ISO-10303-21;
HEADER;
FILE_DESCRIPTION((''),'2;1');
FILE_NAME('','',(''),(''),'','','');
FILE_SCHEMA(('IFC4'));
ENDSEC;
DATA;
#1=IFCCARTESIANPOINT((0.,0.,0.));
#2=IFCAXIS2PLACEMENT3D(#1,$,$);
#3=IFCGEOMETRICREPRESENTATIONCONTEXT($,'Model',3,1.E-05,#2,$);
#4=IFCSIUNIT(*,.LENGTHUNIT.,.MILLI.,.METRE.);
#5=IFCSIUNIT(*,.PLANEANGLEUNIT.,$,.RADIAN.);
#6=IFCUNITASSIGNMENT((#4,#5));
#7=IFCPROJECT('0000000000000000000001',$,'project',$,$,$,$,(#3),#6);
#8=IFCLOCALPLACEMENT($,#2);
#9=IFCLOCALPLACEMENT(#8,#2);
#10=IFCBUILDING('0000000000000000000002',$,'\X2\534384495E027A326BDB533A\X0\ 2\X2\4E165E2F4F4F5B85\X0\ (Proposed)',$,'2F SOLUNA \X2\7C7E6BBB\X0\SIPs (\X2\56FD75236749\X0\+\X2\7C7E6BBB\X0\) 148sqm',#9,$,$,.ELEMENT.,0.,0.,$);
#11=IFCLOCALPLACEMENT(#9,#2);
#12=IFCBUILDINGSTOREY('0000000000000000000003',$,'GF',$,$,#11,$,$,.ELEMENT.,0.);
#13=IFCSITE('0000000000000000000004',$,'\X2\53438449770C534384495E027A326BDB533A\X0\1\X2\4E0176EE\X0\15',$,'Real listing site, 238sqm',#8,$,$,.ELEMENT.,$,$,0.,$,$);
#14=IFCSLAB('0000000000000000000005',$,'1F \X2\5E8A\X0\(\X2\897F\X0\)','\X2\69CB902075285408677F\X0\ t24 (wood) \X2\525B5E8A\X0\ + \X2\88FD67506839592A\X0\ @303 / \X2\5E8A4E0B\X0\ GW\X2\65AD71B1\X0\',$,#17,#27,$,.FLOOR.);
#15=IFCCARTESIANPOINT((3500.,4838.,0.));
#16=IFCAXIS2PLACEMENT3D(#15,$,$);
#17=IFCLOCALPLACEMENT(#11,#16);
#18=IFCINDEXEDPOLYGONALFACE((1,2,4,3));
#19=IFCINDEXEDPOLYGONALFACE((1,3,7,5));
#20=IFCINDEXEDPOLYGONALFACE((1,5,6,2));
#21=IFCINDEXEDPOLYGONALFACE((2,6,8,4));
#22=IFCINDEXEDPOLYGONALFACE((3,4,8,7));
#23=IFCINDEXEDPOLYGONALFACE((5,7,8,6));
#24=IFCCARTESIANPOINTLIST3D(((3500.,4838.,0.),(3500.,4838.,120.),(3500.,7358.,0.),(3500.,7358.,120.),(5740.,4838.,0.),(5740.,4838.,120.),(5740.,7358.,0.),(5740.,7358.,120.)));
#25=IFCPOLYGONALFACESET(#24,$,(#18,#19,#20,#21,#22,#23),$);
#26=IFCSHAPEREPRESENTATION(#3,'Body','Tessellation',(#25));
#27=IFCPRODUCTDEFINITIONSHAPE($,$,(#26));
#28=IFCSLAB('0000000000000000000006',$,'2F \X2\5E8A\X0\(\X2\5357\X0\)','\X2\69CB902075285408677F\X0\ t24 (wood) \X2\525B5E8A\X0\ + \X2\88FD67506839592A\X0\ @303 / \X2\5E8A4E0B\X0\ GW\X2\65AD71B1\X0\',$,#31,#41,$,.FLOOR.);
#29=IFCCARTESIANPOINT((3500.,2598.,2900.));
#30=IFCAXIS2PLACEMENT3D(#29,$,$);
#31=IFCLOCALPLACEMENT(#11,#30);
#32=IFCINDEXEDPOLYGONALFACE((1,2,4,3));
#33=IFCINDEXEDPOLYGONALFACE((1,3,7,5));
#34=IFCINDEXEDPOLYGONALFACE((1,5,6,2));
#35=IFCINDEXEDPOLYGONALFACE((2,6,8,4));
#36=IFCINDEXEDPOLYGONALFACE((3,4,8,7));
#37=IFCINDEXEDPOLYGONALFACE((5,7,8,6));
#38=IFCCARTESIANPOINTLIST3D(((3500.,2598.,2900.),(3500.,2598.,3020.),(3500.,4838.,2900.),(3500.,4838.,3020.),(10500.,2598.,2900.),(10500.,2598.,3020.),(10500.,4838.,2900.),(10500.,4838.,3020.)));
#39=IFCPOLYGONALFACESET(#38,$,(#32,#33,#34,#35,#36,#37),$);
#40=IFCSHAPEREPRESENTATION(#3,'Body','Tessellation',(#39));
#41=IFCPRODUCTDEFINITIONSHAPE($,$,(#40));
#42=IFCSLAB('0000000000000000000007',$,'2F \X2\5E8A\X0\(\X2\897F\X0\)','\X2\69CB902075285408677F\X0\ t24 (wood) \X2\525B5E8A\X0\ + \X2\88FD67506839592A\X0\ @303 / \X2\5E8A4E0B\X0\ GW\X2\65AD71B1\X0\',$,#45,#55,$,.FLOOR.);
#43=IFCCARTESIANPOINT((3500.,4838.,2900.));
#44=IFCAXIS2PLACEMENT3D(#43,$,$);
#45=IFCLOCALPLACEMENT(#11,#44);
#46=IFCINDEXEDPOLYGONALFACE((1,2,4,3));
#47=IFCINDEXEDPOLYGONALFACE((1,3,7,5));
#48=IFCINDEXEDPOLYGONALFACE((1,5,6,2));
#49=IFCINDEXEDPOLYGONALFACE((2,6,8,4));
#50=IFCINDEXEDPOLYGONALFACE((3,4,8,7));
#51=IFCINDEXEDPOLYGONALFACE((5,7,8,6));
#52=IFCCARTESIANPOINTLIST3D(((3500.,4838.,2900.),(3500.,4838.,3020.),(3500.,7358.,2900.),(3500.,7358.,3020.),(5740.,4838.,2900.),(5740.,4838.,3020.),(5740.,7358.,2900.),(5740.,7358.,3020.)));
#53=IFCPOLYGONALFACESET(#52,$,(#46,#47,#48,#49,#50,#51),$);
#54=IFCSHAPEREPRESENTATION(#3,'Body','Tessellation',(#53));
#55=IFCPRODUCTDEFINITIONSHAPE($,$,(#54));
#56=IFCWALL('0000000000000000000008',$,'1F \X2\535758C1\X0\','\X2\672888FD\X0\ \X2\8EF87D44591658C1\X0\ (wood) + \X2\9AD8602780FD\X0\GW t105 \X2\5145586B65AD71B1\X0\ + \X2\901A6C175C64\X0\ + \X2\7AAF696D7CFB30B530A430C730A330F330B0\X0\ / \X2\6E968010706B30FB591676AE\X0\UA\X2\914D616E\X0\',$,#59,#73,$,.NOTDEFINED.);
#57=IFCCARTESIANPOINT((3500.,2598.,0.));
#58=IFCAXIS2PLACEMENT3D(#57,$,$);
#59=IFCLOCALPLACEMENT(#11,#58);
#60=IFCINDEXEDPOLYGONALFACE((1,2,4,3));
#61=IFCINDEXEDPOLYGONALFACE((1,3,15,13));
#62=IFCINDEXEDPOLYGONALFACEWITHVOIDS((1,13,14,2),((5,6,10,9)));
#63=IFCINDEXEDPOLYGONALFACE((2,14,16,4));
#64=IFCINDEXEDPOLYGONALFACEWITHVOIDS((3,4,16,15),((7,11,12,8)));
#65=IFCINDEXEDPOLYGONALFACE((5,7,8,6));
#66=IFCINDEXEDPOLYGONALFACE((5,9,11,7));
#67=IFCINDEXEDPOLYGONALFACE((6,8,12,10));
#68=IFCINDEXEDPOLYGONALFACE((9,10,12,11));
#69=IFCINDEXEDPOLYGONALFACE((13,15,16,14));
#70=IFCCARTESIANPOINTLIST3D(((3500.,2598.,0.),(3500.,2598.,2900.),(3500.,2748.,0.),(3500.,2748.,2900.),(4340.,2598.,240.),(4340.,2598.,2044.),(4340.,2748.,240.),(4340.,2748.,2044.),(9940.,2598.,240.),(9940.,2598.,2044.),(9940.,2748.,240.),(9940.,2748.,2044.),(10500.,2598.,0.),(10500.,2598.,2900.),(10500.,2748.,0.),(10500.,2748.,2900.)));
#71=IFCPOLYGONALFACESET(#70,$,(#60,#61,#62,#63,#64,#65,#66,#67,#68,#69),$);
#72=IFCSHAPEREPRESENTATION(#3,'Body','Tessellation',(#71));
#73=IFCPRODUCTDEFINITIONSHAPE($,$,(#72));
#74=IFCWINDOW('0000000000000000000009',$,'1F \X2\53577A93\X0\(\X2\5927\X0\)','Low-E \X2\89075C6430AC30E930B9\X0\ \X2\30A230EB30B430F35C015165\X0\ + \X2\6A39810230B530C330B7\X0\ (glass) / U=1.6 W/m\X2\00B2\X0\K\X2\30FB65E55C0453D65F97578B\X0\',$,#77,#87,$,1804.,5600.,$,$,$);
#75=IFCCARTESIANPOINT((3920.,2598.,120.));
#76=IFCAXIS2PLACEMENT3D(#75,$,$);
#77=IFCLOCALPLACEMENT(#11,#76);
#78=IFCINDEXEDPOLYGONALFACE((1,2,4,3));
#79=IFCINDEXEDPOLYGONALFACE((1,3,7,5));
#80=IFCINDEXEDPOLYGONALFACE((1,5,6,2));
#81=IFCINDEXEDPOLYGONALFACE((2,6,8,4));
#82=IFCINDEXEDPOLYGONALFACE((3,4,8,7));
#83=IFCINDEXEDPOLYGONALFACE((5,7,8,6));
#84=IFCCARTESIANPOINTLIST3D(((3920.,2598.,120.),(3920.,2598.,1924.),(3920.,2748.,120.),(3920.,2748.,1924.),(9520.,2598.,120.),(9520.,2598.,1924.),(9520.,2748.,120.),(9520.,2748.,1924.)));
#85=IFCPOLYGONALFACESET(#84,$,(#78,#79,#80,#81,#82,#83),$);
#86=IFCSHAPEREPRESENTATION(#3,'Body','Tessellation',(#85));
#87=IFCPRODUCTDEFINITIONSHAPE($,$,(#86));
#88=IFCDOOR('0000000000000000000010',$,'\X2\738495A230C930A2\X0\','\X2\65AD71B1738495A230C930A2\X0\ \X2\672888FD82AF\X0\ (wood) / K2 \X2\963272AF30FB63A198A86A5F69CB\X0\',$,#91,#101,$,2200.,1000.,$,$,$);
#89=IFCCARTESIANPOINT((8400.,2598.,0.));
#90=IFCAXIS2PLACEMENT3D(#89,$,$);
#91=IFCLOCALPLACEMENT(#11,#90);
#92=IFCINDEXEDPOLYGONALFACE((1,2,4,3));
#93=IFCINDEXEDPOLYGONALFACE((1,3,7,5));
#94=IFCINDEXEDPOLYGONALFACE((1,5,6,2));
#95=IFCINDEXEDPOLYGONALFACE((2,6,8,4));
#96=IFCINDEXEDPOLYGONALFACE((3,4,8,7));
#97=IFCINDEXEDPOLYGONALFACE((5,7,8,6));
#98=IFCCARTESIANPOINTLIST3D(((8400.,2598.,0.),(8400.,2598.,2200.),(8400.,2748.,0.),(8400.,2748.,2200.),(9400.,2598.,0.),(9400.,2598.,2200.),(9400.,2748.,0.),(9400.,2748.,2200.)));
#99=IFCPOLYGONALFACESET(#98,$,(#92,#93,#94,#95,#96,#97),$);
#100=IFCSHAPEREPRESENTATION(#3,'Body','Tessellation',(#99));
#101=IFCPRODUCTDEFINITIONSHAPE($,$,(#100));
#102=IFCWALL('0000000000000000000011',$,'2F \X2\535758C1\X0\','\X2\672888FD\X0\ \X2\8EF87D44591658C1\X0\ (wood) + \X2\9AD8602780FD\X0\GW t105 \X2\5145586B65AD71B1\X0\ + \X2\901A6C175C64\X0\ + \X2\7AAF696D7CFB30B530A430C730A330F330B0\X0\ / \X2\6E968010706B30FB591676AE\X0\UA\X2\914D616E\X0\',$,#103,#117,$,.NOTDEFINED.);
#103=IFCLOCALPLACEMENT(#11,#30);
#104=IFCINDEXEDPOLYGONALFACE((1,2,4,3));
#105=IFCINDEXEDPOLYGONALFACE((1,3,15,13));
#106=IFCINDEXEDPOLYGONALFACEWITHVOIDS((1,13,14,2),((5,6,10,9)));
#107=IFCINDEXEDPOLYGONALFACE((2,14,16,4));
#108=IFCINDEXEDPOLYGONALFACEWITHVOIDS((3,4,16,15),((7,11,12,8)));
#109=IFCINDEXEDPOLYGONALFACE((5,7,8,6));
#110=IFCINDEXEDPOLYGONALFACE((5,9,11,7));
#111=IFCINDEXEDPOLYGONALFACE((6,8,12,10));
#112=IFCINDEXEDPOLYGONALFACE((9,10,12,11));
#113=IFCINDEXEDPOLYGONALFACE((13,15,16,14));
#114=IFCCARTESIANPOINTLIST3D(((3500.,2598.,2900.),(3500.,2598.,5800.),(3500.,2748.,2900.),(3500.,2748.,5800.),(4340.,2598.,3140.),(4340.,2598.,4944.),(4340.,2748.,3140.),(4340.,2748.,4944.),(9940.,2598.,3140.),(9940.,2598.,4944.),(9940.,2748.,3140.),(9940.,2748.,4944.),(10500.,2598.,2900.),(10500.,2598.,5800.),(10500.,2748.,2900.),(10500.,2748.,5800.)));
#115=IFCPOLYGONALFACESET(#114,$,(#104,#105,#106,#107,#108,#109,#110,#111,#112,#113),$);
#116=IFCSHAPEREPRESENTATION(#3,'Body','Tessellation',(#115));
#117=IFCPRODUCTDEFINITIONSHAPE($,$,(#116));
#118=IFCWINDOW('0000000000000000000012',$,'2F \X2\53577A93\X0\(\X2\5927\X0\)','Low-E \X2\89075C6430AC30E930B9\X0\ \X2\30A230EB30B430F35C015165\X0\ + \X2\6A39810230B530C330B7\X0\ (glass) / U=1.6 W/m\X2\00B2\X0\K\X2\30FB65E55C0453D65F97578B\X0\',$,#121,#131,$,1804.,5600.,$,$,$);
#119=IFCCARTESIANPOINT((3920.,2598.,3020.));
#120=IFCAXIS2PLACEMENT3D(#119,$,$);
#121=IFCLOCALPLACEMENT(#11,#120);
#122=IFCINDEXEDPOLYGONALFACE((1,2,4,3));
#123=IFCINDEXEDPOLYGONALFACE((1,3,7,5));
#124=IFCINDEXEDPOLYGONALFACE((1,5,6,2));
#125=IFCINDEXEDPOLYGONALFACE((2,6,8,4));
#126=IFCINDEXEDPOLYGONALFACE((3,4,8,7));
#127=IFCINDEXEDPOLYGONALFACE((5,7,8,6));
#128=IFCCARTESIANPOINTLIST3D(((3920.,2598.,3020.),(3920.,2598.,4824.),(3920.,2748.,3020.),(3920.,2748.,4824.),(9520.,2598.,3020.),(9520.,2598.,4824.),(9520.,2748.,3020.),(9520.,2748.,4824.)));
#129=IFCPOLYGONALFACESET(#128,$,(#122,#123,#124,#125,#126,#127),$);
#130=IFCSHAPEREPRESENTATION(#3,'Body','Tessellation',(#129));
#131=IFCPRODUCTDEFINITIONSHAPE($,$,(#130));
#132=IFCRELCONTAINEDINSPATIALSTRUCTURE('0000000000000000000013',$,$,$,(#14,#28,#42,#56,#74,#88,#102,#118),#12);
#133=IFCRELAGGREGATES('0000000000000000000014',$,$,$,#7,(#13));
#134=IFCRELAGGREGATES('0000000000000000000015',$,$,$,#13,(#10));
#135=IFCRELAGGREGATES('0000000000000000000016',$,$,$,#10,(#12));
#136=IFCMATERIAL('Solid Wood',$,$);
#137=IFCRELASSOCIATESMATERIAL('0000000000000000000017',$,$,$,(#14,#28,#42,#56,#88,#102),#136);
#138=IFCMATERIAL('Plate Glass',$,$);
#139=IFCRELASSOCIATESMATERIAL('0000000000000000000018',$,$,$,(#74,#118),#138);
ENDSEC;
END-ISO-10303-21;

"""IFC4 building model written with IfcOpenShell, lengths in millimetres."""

from ifc_helpers import new_model, si_unit, frame, frame_2d, origin, place, context, project, spatial, rectangle, extrude, material, element, fill, save


model = new_model("IFC4")

# Units and contexts
model_context = context("Model", 3, precision=1e-05, world=origin())
ifc_project = project(units=[si_unit("LENGTHUNIT", "METRE", prefix="MILLI"), si_unit("PLANEANGLEUNIT", "RADIAN")], contexts=[model_context])

# Site, building, storey
site_placement = place(None, origin())
site = spatial("IfcSite", under=ifc_project, at=site_placement, Name="千葉県千葉市稲毛区1丁目15", ObjectType="Real listing site, 238sqm", CompositionType="ELEMENT", RefElevation=0.0)
building_placement = place(site_placement, origin())
building = spatial("IfcBuilding", under=site, at=building_placement, Name="千葉市稲毛区 2世帯住宅 (Proposed)", ObjectType="2F SOLUNA 籾殻SIPs (国産杉+籾殻) 148sqm", CompositionType="ELEMENT", ElevationOfRefHeight=0.0, ElevationOfTerrain=0.0)
storey_placement = place(building_placement, origin())
storey = spatial("IfcBuildingStorey", under=building, at=storey_placement, Name="GF", CompositionType="ELEMENT", Elevation=0.0)

# Slabs
ifc_material_1 = material(Name="Solid Wood")
slab_1_placement = place(storey_placement, frame((3500.0, 4838.0, 0.0)))
element("IfcSlab", 1, at=slab_1_placement, inside=storey, material=ifc_material_1, Name="1F 床(西)", Description="構造用合板 t24 (wood) 剛床 + 製材根太 @303 / 床下 GW断熱", PredefinedType="FLOOR", context=model_context, shape_type="SweptSolid", body=[
    extrude(rectangle(XDim=2240.0, YDim=2520.0, at=frame_2d((1120.0, 1260.0))), frame((3500.0, 4838.0, 0.0)), (0.0, 0.0, 1.0), 120.0),
])
slab_2_placement = place(storey_placement, frame((3500.0, 2598.0, 2900.0)))
element("IfcSlab", 2, at=slab_2_placement, inside=storey, material=ifc_material_1, Name="2F 床(南)", Description="構造用合板 t24 (wood) 剛床 + 製材根太 @303 / 床下 GW断熱", PredefinedType="FLOOR", context=model_context, shape_type="SweptSolid", body=[
    extrude(rectangle(XDim=7000.0, YDim=2240.0, at=frame_2d((3500.0, 1120.0))), frame((3500.0, 2598.0, 2900.0)), (0.0, 0.0, 1.0), 120.0),
])
slab_3_placement = place(storey_placement, frame((3500.0, 4838.0, 2900.0)))
element("IfcSlab", 3, at=slab_3_placement, inside=storey, material=ifc_material_1, Name="2F 床(西)", Description="構造用合板 t24 (wood) 剛床 + 製材根太 @303 / 床下 GW断熱", PredefinedType="FLOOR", context=model_context, shape_type="SweptSolid", body=[
    extrude(rectangle(XDim=2240.0, YDim=2520.0, at=frame_2d((1120.0, 1260.0))), frame((3500.0, 4838.0, 2900.0)), (0.0, 0.0, 1.0), 120.0),
])

# Wall, openings, window, door
wall_1_placement = place(storey_placement, frame((3500.0, 2598.0, 0.0)))
wall_1 = element("IfcWall", 4, at=wall_1_placement, inside=storey, material=ifc_material_1, Name="1F 南壁", Description="木製 軸組外壁 (wood) + 高性能GW t105 充填断熱 + 通気層 + 窯業系サイディング / 準耐火・外皮UA配慮", PredefinedType="NOTDEFINED", context=model_context, shape_type="SweptSolid", body=[
    extrude(rectangle(XDim=7000.0, YDim=150.0, at=frame_2d((3500.0, 75.0))), frame((3500.0, 2598.0, 0.0)), (0.0, 0.0, 1.0), 2900.0),
])
opening_1_placement = place(storey_placement, frame((3920.0, 2598.0, 120.0)))
opening_1 = element("IfcOpeningElement", 5, at=opening_1_placement, cuts=wall_1, PredefinedType="NOTDEFINED", context=model_context, shape_type="SweptSolid", body=[
    extrude(rectangle(XDim=5600.0, YDim=150.0, at=frame_2d((2800.0, 75.0))), frame((3920.0, 2598.0, 120.0)), (0.0, 0.0, 1.0), 1804.0),
])
opening_2_placement = place(storey_placement, frame((8400.0, 2598.0, 0.0)))
opening_2 = element("IfcOpeningElement", 6, at=opening_2_placement, cuts=wall_1, PredefinedType="NOTDEFINED", context=model_context, shape_type="SweptSolid", body=[
    extrude(rectangle(XDim=1000.0, YDim=150.0, at=frame_2d((500.0, 75.0))), frame((8400.0, 2598.0, 0.0)), (0.0, 0.0, 1.0), 2200.0),
])
ifc_material_2 = material(Name="Plate Glass")
window_1_placement = place(storey_placement, frame((3920.0, 2598.0, 120.0)))
window_1 = element("IfcWindow", 7, at=window_1_placement, inside=storey, material=ifc_material_2, Name="1F 南窓(大)", Description="Low-E 複層ガラス アルゴン封入 + 樹脂サッシ (glass) / U=1.6 W/m²K・日射取得型", OverallHeight=1804.0, OverallWidth=5600.0, context=model_context, shape_type="SweptSolid", body=[
    extrude(rectangle(XDim=5600.0, YDim=150.0, at=frame_2d((2800.0, 75.0))), frame((3920.0, 2598.0, 120.0)), (0.0, 0.0, 1.0), 1804.0),
])
fill(opening_1, window_1)
door_placement = place(storey_placement, frame((8400.0, 2598.0, 0.0)))
door = element("IfcDoor", 8, at=door_placement, inside=storey, material=ifc_material_1, Name="玄関ドア", Description="断熱玄関ドア 木製芯 (wood) / K2 防犯・採風機構", OverallHeight=2200.0, OverallWidth=1000.0, context=model_context, shape_type="SweptSolid", body=[
    extrude(rectangle(XDim=1000.0, YDim=150.0, at=frame_2d((500.0, 75.0))), frame((8400.0, 2598.0, 0.0)), (0.0, 0.0, 1.0), 2200.0),
])
fill(opening_2, door)

# Wall, opening, window
wall_2_placement = place(storey_placement, frame((3500.0, 2598.0, 2900.0)))
wall_2 = element("IfcWall", 9, at=wall_2_placement, inside=storey, material=ifc_material_1, Name="2F 南壁", Description="木製 軸組外壁 (wood) + 高性能GW t105 充填断熱 + 通気層 + 窯業系サイディング / 準耐火・外皮UA配慮", PredefinedType="NOTDEFINED", context=model_context, shape_type="SweptSolid", body=[
    extrude(rectangle(XDim=7000.0, YDim=150.0, at=frame_2d((3500.0, 75.0))), frame((3500.0, 2598.0, 2900.0)), (0.0, 0.0, 1.0), 2900.0),
])
opening_3_placement = place(storey_placement, frame((3920.0, 2598.0, 3020.0)))
opening_3 = element("IfcOpeningElement", 10, at=opening_3_placement, cuts=wall_2, PredefinedType="NOTDEFINED", context=model_context, shape_type="SweptSolid", body=[
    extrude(rectangle(XDim=5600.0, YDim=150.0, at=frame_2d((2800.0, 75.0))), frame((3920.0, 2598.0, 3020.0)), (0.0, 0.0, 1.0), 1804.0),
])
window_2_placement = place(storey_placement, frame((3920.0, 2598.0, 3020.0)))
window_2 = element("IfcWindow", 11, at=window_2_placement, inside=storey, material=ifc_material_2, Name="2F 南窓(大)", Description="Low-E 複層ガラス アルゴン封入 + 樹脂サッシ (glass) / U=1.6 W/m²K・日射取得型", OverallHeight=1804.0, OverallWidth=5600.0, context=model_context, shape_type="SweptSolid", body=[
    extrude(rectangle(XDim=5600.0, YDim=150.0, at=frame_2d((2800.0, 75.0))), frame((3920.0, 2598.0, 3020.0)), (0.0, 0.0, 1.0), 1804.0),
])
fill(opening_3, window_2)

save(model, "model.ifc")
